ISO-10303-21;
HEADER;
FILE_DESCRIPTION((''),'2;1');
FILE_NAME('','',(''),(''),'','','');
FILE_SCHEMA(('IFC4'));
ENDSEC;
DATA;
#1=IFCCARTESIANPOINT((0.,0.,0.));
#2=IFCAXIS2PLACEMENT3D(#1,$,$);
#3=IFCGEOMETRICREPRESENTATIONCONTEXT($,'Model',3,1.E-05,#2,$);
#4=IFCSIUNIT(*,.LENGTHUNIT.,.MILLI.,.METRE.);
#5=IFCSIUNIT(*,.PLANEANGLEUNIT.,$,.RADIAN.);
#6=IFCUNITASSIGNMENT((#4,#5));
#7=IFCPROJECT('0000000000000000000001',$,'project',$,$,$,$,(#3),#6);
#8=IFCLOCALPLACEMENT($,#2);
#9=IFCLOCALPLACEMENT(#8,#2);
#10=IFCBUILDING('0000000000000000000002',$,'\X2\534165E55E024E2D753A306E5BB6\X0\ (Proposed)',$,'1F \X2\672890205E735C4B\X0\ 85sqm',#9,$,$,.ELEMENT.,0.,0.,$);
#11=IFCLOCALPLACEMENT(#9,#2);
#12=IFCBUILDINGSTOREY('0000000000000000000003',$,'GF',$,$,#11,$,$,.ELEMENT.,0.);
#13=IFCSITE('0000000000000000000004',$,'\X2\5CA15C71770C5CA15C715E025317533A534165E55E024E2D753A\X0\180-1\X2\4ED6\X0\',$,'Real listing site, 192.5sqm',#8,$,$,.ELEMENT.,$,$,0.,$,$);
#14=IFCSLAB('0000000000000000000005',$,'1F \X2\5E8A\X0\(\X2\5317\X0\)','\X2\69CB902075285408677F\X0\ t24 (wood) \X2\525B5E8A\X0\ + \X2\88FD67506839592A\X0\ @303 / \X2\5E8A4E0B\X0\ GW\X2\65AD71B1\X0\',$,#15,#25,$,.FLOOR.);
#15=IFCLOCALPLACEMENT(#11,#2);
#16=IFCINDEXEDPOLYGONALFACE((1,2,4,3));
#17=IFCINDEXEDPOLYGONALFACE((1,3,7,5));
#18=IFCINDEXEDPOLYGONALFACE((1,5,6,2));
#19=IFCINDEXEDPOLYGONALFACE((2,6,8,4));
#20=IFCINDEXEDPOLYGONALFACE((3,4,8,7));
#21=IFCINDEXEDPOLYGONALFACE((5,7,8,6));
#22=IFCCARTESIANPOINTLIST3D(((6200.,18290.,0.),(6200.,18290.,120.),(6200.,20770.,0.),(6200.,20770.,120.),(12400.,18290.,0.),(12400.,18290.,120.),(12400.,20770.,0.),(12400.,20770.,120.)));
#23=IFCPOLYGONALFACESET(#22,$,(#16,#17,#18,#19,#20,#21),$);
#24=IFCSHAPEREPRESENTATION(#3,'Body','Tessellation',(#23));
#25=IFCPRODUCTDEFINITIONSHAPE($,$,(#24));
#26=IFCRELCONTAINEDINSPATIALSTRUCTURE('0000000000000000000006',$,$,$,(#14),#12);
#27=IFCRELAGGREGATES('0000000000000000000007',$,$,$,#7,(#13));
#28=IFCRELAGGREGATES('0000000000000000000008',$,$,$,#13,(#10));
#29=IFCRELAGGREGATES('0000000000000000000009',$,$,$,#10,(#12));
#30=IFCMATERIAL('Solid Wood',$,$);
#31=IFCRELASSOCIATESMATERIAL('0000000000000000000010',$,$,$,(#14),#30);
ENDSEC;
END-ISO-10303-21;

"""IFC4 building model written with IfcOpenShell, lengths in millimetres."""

from ifc_helpers import new_model, si_unit, frame, frame_2d, origin, place, context, project, spatial, rectangle, extrude, material, element, save


model = new_model("IFC4")

# Units and contexts
model_context = context("Model", 3, precision=1e-05, world=origin())
ifc_project = project(units=[si_unit("LENGTHUNIT", "METRE", prefix="MILLI"), si_unit("PLANEANGLEUNIT", "RADIAN")], contexts=[model_context])

# Site, building, storey
site_placement = place(None, origin())
site = spatial("IfcSite", under=ifc_project, at=site_placement, Name="岡山県岡山市北区十日市中町180-1他", ObjectType="Real listing site, 192.5sqm", CompositionType="ELEMENT", RefElevation=0.0)
building_placement = place(site_placement, origin())
building = spatial("IfcBuilding", under=site, at=building_placement, Name="十日市中町の家 (Proposed)", ObjectType="1F 木造平屋 85sqm", CompositionType="ELEMENT", ElevationOfRefHeight=0.0, ElevationOfTerrain=0.0)
storey_placement = place(building_placement, origin())
storey = spatial("IfcBuildingStorey", under=building, at=storey_placement, Name="GF", CompositionType="ELEMENT", Elevation=0.0)

# Slab
ifc_material_1 = material(Name="Solid Wood")
slab_1_placement = place(storey_placement, frame((3100.0, 9145.0, 0.0)))
element("IfcSlab", 1, at=slab_1_placement, inside=storey, material=ifc_material_1, Name="1F 床(北)", Description="構造用合板 t24 (wood) 剛床 + 製材根太 @303 / 床下 GW断熱", PredefinedType="FLOOR", context=model_context, shape_type="SweptSolid", body=[
    extrude(rectangle(XDim=6200.0, YDim=2480.0, at=frame_2d((3100.0, 1240.0))), frame((3100.0, 9145.0, 0.0)), (0.0, 0.0, 1.0), 120.0),
])

save(model, "model.ifc")
